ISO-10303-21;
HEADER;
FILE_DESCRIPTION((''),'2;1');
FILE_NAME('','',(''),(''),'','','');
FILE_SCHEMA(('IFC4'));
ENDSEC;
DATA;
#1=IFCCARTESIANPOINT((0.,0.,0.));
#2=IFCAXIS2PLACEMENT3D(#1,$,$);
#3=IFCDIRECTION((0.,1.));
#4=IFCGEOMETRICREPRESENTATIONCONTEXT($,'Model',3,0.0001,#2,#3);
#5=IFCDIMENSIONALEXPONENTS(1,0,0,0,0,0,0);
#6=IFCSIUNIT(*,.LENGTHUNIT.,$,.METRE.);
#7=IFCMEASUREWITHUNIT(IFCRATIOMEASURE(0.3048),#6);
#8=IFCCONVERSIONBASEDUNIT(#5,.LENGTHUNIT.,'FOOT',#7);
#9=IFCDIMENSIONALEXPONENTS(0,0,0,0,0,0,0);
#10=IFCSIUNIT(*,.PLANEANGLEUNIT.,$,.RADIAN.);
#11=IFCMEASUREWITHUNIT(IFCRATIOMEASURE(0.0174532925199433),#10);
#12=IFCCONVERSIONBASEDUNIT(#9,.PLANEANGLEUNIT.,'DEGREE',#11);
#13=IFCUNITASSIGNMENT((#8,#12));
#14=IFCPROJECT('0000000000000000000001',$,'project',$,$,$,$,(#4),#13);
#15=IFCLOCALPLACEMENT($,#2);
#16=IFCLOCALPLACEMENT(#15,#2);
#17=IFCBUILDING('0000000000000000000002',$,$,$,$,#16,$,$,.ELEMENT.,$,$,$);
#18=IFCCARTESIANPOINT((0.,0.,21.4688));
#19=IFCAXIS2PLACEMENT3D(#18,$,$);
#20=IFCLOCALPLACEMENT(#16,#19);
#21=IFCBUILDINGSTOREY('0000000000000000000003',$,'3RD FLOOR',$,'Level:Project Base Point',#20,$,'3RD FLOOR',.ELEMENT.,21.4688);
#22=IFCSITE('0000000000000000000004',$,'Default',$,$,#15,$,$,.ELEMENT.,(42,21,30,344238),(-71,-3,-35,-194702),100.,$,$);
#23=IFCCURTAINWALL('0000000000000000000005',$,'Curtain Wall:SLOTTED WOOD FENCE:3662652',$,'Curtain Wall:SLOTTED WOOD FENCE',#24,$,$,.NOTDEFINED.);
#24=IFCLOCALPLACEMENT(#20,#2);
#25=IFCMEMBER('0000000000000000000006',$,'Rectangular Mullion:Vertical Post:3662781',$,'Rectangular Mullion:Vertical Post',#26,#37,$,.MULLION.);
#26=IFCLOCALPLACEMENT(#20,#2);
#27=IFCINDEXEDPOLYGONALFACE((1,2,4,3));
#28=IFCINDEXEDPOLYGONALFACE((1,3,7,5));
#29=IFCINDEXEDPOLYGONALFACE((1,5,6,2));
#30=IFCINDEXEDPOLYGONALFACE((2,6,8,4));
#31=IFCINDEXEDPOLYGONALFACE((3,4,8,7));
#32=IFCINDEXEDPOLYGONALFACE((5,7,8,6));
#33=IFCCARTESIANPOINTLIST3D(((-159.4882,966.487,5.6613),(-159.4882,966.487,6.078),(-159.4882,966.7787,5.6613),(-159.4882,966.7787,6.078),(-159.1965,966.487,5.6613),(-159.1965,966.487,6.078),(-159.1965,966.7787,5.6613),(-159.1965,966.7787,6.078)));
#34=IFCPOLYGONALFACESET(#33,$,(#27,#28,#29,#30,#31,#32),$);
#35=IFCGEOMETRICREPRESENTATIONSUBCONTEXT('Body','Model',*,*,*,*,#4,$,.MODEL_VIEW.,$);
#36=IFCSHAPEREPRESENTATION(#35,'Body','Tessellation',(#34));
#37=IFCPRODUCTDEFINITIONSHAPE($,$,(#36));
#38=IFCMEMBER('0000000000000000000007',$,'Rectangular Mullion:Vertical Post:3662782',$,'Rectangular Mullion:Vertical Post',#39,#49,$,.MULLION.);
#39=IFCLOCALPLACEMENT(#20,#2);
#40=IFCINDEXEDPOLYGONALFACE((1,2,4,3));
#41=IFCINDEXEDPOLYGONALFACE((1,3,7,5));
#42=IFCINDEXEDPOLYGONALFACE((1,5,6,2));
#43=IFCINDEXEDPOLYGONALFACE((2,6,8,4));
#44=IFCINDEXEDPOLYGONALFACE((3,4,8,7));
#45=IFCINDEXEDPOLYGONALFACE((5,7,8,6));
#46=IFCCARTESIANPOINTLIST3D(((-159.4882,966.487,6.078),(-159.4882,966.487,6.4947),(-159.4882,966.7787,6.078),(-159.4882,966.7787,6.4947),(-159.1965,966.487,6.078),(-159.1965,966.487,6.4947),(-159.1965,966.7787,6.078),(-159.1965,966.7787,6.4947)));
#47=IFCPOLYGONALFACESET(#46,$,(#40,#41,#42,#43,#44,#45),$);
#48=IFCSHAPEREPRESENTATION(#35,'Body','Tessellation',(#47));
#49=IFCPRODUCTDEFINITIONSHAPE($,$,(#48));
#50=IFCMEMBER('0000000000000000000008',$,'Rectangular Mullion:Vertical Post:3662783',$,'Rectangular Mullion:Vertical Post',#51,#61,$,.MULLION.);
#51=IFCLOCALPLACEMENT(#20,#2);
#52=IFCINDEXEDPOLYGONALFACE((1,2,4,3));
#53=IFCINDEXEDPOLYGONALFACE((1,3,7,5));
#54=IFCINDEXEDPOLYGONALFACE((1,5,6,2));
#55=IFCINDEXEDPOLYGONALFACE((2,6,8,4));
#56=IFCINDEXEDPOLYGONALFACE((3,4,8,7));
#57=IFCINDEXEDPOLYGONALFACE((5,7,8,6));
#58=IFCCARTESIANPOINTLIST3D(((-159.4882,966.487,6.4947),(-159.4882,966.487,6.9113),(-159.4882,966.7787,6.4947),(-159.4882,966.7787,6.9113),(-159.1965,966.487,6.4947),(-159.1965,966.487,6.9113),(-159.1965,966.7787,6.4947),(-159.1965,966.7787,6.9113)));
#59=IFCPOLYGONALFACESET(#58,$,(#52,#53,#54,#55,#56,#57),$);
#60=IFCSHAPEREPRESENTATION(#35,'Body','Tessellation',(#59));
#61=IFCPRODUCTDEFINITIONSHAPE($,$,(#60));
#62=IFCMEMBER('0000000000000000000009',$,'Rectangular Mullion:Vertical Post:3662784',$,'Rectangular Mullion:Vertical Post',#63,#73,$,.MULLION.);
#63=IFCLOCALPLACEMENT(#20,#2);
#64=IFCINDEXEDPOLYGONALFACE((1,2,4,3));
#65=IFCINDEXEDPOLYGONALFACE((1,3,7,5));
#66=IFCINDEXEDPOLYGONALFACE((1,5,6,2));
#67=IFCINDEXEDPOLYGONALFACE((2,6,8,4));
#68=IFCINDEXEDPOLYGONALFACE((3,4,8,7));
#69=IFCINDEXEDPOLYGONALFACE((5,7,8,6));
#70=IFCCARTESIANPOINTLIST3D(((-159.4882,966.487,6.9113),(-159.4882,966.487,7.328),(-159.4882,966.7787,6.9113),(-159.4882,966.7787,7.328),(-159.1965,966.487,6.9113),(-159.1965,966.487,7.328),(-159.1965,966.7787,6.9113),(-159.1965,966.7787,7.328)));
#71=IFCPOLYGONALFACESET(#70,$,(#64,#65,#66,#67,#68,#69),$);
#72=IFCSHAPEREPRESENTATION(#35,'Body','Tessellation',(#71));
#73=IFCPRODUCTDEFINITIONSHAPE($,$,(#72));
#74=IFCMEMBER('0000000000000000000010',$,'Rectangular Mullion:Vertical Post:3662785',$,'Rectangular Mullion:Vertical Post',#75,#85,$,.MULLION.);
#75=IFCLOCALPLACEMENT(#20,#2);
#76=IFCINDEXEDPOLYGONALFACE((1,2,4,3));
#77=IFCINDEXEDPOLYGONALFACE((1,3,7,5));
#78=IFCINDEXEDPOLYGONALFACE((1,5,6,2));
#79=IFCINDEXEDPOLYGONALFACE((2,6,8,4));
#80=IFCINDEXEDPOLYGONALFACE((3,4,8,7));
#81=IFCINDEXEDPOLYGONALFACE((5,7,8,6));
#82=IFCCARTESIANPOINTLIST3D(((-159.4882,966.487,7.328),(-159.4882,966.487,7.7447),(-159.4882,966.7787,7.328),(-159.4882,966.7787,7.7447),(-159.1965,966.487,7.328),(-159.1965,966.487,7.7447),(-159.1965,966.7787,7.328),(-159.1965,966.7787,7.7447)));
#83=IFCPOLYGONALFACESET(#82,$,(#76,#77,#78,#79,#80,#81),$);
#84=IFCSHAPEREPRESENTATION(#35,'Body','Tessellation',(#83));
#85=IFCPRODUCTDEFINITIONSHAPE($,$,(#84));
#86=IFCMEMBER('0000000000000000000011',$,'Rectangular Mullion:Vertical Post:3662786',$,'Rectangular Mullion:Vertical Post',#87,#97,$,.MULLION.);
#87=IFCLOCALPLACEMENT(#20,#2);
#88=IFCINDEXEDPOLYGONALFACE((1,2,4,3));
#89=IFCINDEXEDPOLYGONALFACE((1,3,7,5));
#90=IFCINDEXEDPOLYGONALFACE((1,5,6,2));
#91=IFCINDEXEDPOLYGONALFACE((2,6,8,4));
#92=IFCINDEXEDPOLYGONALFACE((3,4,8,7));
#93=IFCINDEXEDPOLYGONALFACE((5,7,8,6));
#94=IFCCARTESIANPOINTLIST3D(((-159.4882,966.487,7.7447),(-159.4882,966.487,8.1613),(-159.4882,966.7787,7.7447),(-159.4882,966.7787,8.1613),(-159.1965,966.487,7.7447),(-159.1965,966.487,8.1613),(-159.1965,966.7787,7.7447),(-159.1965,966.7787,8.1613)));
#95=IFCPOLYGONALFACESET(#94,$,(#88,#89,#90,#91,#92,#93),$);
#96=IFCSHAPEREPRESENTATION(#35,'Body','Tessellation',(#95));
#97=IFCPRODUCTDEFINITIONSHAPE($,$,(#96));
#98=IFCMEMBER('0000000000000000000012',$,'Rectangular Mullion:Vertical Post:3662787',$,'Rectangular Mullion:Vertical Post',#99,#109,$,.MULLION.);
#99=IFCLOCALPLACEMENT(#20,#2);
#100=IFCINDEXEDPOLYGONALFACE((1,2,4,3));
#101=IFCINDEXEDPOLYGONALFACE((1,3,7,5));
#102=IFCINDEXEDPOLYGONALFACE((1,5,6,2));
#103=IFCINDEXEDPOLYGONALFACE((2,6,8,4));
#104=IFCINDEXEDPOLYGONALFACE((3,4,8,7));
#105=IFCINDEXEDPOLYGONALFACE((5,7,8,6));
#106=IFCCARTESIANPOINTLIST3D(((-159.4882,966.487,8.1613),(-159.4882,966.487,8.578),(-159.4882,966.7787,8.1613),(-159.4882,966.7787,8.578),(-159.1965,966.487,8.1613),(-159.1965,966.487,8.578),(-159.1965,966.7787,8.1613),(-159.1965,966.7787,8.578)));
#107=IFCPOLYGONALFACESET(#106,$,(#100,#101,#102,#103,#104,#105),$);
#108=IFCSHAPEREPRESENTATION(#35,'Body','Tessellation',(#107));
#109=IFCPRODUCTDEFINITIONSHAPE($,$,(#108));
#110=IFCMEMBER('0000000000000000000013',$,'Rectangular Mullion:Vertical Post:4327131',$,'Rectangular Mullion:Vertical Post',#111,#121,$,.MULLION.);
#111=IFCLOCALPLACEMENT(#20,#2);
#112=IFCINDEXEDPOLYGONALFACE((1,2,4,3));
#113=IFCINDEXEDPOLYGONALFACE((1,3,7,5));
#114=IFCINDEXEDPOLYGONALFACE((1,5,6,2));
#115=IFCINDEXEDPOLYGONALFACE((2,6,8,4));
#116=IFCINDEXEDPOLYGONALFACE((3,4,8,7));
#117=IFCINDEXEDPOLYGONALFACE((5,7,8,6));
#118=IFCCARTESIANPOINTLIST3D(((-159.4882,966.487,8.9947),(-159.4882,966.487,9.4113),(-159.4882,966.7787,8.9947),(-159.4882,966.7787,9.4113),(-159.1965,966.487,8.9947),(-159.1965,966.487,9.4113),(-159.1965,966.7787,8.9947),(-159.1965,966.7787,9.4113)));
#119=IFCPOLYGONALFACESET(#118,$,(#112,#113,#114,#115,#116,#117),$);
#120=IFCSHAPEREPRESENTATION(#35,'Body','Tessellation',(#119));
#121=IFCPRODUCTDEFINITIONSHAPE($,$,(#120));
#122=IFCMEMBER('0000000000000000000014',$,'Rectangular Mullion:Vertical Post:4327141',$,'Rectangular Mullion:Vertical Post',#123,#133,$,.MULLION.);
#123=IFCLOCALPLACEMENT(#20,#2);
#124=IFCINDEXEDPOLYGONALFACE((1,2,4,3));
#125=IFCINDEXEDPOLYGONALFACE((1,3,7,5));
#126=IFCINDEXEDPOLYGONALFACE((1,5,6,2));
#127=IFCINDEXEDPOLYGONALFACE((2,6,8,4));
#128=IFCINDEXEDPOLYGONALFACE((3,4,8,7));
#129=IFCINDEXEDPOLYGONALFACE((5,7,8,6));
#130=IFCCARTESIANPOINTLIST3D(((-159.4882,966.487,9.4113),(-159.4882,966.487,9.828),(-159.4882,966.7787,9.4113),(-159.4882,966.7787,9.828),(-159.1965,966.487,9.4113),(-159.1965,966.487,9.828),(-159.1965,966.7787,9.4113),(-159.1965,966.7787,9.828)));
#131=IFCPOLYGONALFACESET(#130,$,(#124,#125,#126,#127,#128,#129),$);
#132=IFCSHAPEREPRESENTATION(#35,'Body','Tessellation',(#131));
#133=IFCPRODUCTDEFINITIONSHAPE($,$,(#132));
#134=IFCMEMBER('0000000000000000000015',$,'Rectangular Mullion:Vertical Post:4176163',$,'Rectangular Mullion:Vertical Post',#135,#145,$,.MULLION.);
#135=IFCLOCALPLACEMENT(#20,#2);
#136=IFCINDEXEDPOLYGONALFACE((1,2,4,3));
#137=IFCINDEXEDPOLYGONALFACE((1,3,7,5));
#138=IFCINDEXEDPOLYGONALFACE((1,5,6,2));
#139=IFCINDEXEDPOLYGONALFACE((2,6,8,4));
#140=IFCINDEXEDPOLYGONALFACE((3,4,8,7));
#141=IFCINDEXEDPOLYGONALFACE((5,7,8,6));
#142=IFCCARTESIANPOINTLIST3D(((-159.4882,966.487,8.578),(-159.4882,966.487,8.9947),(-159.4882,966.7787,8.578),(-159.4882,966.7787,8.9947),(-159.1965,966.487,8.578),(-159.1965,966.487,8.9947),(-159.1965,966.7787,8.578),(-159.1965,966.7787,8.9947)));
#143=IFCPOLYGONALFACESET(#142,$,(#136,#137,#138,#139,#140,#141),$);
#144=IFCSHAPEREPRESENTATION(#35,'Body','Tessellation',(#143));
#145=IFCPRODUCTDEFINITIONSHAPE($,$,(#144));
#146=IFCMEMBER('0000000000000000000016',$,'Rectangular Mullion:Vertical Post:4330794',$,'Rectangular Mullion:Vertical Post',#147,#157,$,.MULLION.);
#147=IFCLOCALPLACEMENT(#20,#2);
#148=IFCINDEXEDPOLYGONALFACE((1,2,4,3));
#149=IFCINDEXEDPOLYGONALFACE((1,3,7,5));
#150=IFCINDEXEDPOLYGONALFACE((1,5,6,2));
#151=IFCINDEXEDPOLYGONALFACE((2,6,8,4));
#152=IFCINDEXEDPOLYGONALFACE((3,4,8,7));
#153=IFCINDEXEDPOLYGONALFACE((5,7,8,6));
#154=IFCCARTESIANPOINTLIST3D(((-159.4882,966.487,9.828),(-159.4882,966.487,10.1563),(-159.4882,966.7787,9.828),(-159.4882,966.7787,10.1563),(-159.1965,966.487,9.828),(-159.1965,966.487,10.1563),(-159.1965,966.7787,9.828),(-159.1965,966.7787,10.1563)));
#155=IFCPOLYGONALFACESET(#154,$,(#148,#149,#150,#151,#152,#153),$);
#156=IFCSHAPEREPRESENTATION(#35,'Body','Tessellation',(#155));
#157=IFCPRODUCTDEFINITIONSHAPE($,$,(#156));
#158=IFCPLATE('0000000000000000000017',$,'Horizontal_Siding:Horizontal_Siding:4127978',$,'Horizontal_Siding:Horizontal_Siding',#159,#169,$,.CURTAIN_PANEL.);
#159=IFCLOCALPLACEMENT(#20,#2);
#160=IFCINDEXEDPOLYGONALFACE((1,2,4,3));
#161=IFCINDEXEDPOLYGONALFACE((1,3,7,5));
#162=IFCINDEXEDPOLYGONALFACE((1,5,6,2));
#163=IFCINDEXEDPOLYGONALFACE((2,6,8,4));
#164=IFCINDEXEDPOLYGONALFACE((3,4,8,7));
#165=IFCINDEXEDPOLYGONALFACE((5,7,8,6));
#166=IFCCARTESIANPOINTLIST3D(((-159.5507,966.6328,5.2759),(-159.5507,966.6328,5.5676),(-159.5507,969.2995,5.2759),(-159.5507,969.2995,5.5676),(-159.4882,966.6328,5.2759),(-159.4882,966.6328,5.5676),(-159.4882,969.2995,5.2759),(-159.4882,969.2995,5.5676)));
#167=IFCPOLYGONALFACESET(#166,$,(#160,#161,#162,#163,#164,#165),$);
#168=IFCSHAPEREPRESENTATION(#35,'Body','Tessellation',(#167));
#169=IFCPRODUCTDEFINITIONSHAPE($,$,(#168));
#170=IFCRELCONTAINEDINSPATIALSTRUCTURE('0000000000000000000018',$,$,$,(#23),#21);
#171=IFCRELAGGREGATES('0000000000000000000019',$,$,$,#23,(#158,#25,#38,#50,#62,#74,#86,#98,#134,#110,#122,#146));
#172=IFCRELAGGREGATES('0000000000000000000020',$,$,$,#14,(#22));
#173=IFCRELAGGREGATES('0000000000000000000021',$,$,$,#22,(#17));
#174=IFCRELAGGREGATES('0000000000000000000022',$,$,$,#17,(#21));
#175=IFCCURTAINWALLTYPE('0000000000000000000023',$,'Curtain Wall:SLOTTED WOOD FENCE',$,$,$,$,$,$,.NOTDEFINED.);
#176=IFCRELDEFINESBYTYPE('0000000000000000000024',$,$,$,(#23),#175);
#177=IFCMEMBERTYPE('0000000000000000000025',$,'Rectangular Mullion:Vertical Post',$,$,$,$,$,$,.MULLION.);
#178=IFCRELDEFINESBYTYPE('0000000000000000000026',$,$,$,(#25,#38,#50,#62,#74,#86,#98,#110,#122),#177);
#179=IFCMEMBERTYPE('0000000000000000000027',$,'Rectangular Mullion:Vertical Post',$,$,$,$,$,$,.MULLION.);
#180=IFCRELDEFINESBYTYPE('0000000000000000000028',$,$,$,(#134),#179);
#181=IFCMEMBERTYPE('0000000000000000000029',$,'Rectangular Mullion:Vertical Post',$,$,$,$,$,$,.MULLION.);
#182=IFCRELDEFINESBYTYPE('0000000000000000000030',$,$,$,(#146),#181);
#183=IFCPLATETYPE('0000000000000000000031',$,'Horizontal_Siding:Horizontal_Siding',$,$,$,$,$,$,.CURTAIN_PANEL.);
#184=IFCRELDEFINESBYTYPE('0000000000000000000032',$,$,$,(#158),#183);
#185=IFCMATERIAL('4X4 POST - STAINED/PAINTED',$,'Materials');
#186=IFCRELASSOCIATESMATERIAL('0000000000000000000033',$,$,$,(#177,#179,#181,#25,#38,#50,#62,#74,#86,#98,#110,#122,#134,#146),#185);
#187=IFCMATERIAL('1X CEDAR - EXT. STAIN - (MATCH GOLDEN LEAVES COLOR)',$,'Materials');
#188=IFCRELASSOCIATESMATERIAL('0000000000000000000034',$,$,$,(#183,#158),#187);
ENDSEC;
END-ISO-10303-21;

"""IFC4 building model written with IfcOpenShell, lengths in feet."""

from ifc_helpers import new_model, entity, si_unit, converted_unit, direction, frame, origin, origin_2d_with_axis, place, context, subcontext, project, spatial, rectangle, extrude, source, transform, mapped, material, material_profile, profile_set, profile_usage, type_object, type_shapes, element, aggregate, save


model = new_model("IFC4")

# Units and contexts
model_context = context("Model", 3, precision=0.0001, world=origin(), true_north=direction((0.0, 1.0)))
body_context = subcontext(model_context, "Body", "Model", "MODEL_VIEW")
ifc_project = project(units=[converted_unit("LENGTHUNIT", "FOOT", entity("IfcRatioMeasure", 0.3048), si_unit("LENGTHUNIT", "METRE"), dimensions=[1, 0, 0, 0, 0, 0, 0]), converted_unit("PLANEANGLEUNIT", "DEGREE", entity("IfcRatioMeasure", 0.0174532925199433), si_unit("PLANEANGLEUNIT", "RADIAN"), dimensions=[0, 0, 0, 0, 0, 0, 0])], contexts=[model_context])

# Site, building, storey
site_placement = place(None, origin())
site = spatial("IfcSite", under=ifc_project, at=site_placement, Name="Default", CompositionType="ELEMENT", RefLatitude=(42, 21, 30, 344238), RefLongitude=(-71, -3, -35, -194702), RefElevation=100.0)
building_placement = place(site_placement, origin())
building = spatial("IfcBuilding", under=site, at=building_placement, CompositionType="ELEMENT")
storey_placement = place(building_placement, frame((0.0, 0.0, 21.4688)))
storey = spatial("IfcBuildingStorey", under=building, at=storey_placement, Name="3RD FLOOR", ObjectType="Level:Project Base Point", LongName="3RD FLOOR", CompositionType="ELEMENT", Elevation=21.4688)

# Curtain wall, members, plate
curtain_wall_type = type_object("IfcCurtainWallType", Name="Curtain Wall:SLOTTED WOOD FENCE", PredefinedType="NOTDEFINED")
curtain_wall_placement = place(storey_placement, frame((0.0, 0.0, -21.4688)))
curtain_wall = element("IfcCurtainWall", 1, at=curtain_wall_placement, inside=storey, type_object=curtain_wall_type, Name="Curtain Wall:SLOTTED WOOD FENCE:3662652", ObjectType="Curtain Wall:SLOTTED WOOD FENCE", PredefinedType="NOTDEFINED")
ifc_material_1 = material(Name="4X4 POST - STAINED/PAINTED", Category="Materials")
ifc_material_profile = material_profile(ifc_material_1, rectangle(XDim=0.2917, YDim=0.2917, at=origin_2d_with_axis()), Name="Vertical Post")
ifc_profile_set = profile_set([ifc_material_profile], Name="Vertical Post")
ifc_profile_usage_1 = profile_usage(ifc_profile_set)
member_type_1 = type_object("IfcMemberType", Name="Rectangular Mullion:Vertical Post", PredefinedType="MULLION", material=ifc_profile_set)
shared_shape_1 = source(origin(), body_context, "Body", "SweptSolid", [
    extrude(rectangle(XDim=0.2917, YDim=0.2917, at=origin_2d_with_axis()), frame((0.0, -0.2083, -0.4167), z_axis=(0.0, 0.0, 1.0), x_axis=(0.0, -1.0, 0.0)), (0.0, 0.0, 1.0), 0.4167),
])
type_shapes(member_type_1, [shared_shape_1])
member_1_placement = place(storey_placement, frame((-159.5507, 966.6328, 5.6613), z_axis=(0.0, 0.0, -1.0), x_axis=(0.0, -1.0, 0.0)))
member_1 = element("IfcMember", 2, at=member_1_placement, type_object=member_type_1, material=ifc_profile_usage_1, Name="Rectangular Mullion:Vertical Post:3662781", ObjectType="Rectangular Mullion:Vertical Post", PredefinedType="MULLION", context=body_context, shape_type="MappedRepresentation", body=[
    mapped(shared_shape_1, transform((0.0, 0.0, 0.0), scale=1.0)),
])
ifc_profile_usage_2 = profile_usage(ifc_profile_set)
member_2_placement = place(storey_placement, frame((-159.5507, 966.6328, 6.078), z_axis=(0.0, 0.0, -1.0), x_axis=(0.0, -1.0, 0.0)))
member_2 = element("IfcMember", 3, at=member_2_placement, type_object=member_type_1, material=ifc_profile_usage_2, Name="Rectangular Mullion:Vertical Post:3662782", ObjectType="Rectangular Mullion:Vertical Post", PredefinedType="MULLION", context=body_context, shape_type="MappedRepresentation", body=[
    mapped(shared_shape_1, transform((0.0, 0.0, 0.0), scale=1.0)),
])
ifc_profile_usage_3 = profile_usage(ifc_profile_set)
member_3_placement = place(storey_placement, frame((-159.5507, 966.6328, 6.4947), z_axis=(0.0, 0.0, -1.0), x_axis=(0.0, -1.0, 0.0)))
member_3 = element("IfcMember", 4, at=member_3_placement, type_object=member_type_1, material=ifc_profile_usage_3, Name="Rectangular Mullion:Vertical Post:3662783", ObjectType="Rectangular Mullion:Vertical Post", PredefinedType="MULLION", context=body_context, shape_type="MappedRepresentation", body=[
    mapped(shared_shape_1, transform((0.0, 0.0, 0.0), scale=1.0)),
])
ifc_profile_usage_4 = profile_usage(ifc_profile_set)
member_4_placement = place(storey_placement, frame((-159.5507, 966.6328, 6.9113), z_axis=(0.0, 0.0, -1.0), x_axis=(0.0, -1.0, 0.0)))
member_4 = element("IfcMember", 5, at=member_4_placement, type_object=member_type_1, material=ifc_profile_usage_4, Name="Rectangular Mullion:Vertical Post:3662784", ObjectType="Rectangular Mullion:Vertical Post", PredefinedType="MULLION", context=body_context, shape_type="MappedRepresentation", body=[
    mapped(shared_shape_1, transform((0.0, 0.0, 0.0), scale=1.0)),
])
ifc_profile_usage_5 = profile_usage(ifc_profile_set)
member_5_placement = place(storey_placement, frame((-159.5507, 966.6328, 7.328), z_axis=(0.0, 0.0, -1.0), x_axis=(0.0, -1.0, 0.0)))
member_5 = element("IfcMember", 6, at=member_5_placement, type_object=member_type_1, material=ifc_profile_usage_5, Name="Rectangular Mullion:Vertical Post:3662785", ObjectType="Rectangular Mullion:Vertical Post", PredefinedType="MULLION", context=body_context, shape_type="MappedRepresentation", body=[
    mapped(shared_shape_1, transform((0.0, 0.0, 0.0), scale=1.0)),
])
ifc_profile_usage_6 = profile_usage(ifc_profile_set)
member_6_placement = place(storey_placement, frame((-159.5507, 966.6328, 7.7447), z_axis=(0.0, 0.0, -1.0), x_axis=(0.0, -1.0, 0.0)))
member_6 = element("IfcMember", 7, at=member_6_placement, type_object=member_type_1, material=ifc_profile_usage_6, Name="Rectangular Mullion:Vertical Post:3662786", ObjectType="Rectangular Mullion:Vertical Post", PredefinedType="MULLION", context=body_context, shape_type="MappedRepresentation", body=[
    mapped(shared_shape_1, transform((0.0, 0.0, 0.0), scale=1.0)),
])
ifc_profile_usage_7 = profile_usage(ifc_profile_set)
member_7_placement = place(storey_placement, frame((-159.5507, 966.6328, 8.1613), z_axis=(0.0, 0.0, -1.0), x_axis=(0.0, -1.0, 0.0)))
member_7 = element("IfcMember", 8, at=member_7_placement, type_object=member_type_1, material=ifc_profile_usage_7, Name="Rectangular Mullion:Vertical Post:3662787", ObjectType="Rectangular Mullion:Vertical Post", PredefinedType="MULLION", context=body_context, shape_type="MappedRepresentation", body=[
    mapped(shared_shape_1, transform((0.0, 0.0, 0.0), scale=1.0)),
])
ifc_profile_usage_8 = profile_usage(ifc_profile_set)
member_8_placement = place(storey_placement, frame((-159.5507, 966.6328, 8.9947), z_axis=(0.0, 0.0, -1.0), x_axis=(0.0, -1.0, 0.0)))
member_8 = element("IfcMember", 9, at=member_8_placement, type_object=member_type_1, material=ifc_profile_usage_8, Name="Rectangular Mullion:Vertical Post:4327131", ObjectType="Rectangular Mullion:Vertical Post", PredefinedType="MULLION", context=body_context, shape_type="MappedRepresentation", body=[
    mapped(shared_shape_1, transform((0.0, 0.0, 0.0), scale=1.0)),
])
ifc_profile_usage_9 = profile_usage(ifc_profile_set)
member_9_placement = place(storey_placement, frame((-159.5507, 966.6328, 9.4113), z_axis=(0.0, 0.0, -1.0), x_axis=(0.0, -1.0, 0.0)))
member_9 = element("IfcMember", 10, at=member_9_placement, type_object=member_type_1, material=ifc_profile_usage_9, Name="Rectangular Mullion:Vertical Post:4327141", ObjectType="Rectangular Mullion:Vertical Post", PredefinedType="MULLION", context=body_context, shape_type="MappedRepresentation", body=[
    mapped(shared_shape_1, transform((0.0, 0.0, 0.0), scale=1.0)),
])
ifc_profile_usage_10 = profile_usage(ifc_profile_set)
member_type_2 = type_object("IfcMemberType", Name="Rectangular Mullion:Vertical Post", PredefinedType="MULLION", material=ifc_profile_set)
shared_shape_2 = source(origin(), body_context, "Body", "SweptSolid", [
    extrude(rectangle(XDim=0.2917, YDim=0.2917, at=origin_2d_with_axis()), frame((0.0, -0.2083, -0.4167), z_axis=(0.0, 0.0, 1.0), x_axis=(0.0, -1.0, 0.0)), (0.0, 0.0, 1.0), 0.4167),
])
type_shapes(member_type_2, [shared_shape_2])
member_10_placement = place(storey_placement, frame((-159.5507, 966.6328, 8.578), z_axis=(0.0, 0.0, -1.0), x_axis=(0.0, -1.0, 0.0)))
member_10 = element("IfcMember", 11, at=member_10_placement, type_object=member_type_2, material=ifc_profile_usage_10, Name="Rectangular Mullion:Vertical Post:4176163", ObjectType="Rectangular Mullion:Vertical Post", PredefinedType="MULLION", context=body_context, shape_type="MappedRepresentation", body=[
    mapped(shared_shape_2, transform((0.0, 0.0, 0.0), scale=1.0)),
])
ifc_profile_usage_11 = profile_usage(ifc_profile_set)
member_type_3 = type_object("IfcMemberType", Name="Rectangular Mullion:Vertical Post", PredefinedType="MULLION", material=ifc_profile_set)
shared_shape_3 = source(origin(), body_context, "Body", "SweptSolid", [
    extrude(rectangle(XDim=0.2917, YDim=0.2917, at=origin_2d_with_axis()), frame((0.0, -0.2083, -0.3282), z_axis=(0.0, 0.0, 1.0), x_axis=(0.0, -1.0, 0.0)), (0.0, 0.0, 1.0), 0.3282),
])
type_shapes(member_type_3, [shared_shape_3])
member_11_placement = place(storey_placement, frame((-159.5507, 966.6328, 9.828), z_axis=(0.0, 0.0, -1.0), x_axis=(0.0, -1.0, 0.0)))
member_11 = element("IfcMember", 12, at=member_11_placement, type_object=member_type_3, material=ifc_profile_usage_11, Name="Rectangular Mullion:Vertical Post:4330794", ObjectType="Rectangular Mullion:Vertical Post", PredefinedType="MULLION", context=body_context, shape_type="MappedRepresentation", body=[
    mapped(shared_shape_3, transform((0.0, 0.0, 0.0), scale=1.0)),
])
ifc_material_2 = material(Name="1X CEDAR - EXT. STAIN - (MATCH GOLDEN LEAVES COLOR)", Category="Materials")
plate_type_1 = type_object("IfcPlateType", Name="Horizontal_Siding:Horizontal_Siding", PredefinedType="CURTAIN_PANEL", material=ifc_material_2)
shared_shape_4 = source(origin(), body_context, "Body", "SweptSolid", [
    extrude(rectangle(XDim=2.6667, YDim=0.0625, at=origin_2d_with_axis()), frame((1.3333, 0.0312, 0.0), z_axis=(0.0, 0.0, 1.0), x_axis=(-1.0, 0.0, 0.0)), (0.0, 0.0, 1.0), 0.2917),
])
type_shapes(plate_type_1, [shared_shape_4])
plate_1_placement = place(curtain_wall_placement, frame((-159.5507, 969.2995, 26.7447), z_axis=(0.0, 0.0, 1.0), x_axis=(0.0, -1.0, 0.0)))
plate_1 = element("IfcPlate", 13, at=plate_1_placement, type_object=plate_type_1, material=ifc_material_2, Name="Horizontal_Siding:Horizontal_Siding:4127978", ObjectType="Horizontal_Siding:Horizontal_Siding", PredefinedType="CURTAIN_PANEL", context=body_context, shape_type="MappedRepresentation", body=[
    mapped(shared_shape_4, transform((0.0, 0.0, 0.0), scale=1.0)),
])
aggregate(curtain_wall, [plate_1, member_1, member_2, member_3, member_4, member_5, member_6, member_7, member_10, member_8, member_9, member_11])

save(model, "model.ifc")
